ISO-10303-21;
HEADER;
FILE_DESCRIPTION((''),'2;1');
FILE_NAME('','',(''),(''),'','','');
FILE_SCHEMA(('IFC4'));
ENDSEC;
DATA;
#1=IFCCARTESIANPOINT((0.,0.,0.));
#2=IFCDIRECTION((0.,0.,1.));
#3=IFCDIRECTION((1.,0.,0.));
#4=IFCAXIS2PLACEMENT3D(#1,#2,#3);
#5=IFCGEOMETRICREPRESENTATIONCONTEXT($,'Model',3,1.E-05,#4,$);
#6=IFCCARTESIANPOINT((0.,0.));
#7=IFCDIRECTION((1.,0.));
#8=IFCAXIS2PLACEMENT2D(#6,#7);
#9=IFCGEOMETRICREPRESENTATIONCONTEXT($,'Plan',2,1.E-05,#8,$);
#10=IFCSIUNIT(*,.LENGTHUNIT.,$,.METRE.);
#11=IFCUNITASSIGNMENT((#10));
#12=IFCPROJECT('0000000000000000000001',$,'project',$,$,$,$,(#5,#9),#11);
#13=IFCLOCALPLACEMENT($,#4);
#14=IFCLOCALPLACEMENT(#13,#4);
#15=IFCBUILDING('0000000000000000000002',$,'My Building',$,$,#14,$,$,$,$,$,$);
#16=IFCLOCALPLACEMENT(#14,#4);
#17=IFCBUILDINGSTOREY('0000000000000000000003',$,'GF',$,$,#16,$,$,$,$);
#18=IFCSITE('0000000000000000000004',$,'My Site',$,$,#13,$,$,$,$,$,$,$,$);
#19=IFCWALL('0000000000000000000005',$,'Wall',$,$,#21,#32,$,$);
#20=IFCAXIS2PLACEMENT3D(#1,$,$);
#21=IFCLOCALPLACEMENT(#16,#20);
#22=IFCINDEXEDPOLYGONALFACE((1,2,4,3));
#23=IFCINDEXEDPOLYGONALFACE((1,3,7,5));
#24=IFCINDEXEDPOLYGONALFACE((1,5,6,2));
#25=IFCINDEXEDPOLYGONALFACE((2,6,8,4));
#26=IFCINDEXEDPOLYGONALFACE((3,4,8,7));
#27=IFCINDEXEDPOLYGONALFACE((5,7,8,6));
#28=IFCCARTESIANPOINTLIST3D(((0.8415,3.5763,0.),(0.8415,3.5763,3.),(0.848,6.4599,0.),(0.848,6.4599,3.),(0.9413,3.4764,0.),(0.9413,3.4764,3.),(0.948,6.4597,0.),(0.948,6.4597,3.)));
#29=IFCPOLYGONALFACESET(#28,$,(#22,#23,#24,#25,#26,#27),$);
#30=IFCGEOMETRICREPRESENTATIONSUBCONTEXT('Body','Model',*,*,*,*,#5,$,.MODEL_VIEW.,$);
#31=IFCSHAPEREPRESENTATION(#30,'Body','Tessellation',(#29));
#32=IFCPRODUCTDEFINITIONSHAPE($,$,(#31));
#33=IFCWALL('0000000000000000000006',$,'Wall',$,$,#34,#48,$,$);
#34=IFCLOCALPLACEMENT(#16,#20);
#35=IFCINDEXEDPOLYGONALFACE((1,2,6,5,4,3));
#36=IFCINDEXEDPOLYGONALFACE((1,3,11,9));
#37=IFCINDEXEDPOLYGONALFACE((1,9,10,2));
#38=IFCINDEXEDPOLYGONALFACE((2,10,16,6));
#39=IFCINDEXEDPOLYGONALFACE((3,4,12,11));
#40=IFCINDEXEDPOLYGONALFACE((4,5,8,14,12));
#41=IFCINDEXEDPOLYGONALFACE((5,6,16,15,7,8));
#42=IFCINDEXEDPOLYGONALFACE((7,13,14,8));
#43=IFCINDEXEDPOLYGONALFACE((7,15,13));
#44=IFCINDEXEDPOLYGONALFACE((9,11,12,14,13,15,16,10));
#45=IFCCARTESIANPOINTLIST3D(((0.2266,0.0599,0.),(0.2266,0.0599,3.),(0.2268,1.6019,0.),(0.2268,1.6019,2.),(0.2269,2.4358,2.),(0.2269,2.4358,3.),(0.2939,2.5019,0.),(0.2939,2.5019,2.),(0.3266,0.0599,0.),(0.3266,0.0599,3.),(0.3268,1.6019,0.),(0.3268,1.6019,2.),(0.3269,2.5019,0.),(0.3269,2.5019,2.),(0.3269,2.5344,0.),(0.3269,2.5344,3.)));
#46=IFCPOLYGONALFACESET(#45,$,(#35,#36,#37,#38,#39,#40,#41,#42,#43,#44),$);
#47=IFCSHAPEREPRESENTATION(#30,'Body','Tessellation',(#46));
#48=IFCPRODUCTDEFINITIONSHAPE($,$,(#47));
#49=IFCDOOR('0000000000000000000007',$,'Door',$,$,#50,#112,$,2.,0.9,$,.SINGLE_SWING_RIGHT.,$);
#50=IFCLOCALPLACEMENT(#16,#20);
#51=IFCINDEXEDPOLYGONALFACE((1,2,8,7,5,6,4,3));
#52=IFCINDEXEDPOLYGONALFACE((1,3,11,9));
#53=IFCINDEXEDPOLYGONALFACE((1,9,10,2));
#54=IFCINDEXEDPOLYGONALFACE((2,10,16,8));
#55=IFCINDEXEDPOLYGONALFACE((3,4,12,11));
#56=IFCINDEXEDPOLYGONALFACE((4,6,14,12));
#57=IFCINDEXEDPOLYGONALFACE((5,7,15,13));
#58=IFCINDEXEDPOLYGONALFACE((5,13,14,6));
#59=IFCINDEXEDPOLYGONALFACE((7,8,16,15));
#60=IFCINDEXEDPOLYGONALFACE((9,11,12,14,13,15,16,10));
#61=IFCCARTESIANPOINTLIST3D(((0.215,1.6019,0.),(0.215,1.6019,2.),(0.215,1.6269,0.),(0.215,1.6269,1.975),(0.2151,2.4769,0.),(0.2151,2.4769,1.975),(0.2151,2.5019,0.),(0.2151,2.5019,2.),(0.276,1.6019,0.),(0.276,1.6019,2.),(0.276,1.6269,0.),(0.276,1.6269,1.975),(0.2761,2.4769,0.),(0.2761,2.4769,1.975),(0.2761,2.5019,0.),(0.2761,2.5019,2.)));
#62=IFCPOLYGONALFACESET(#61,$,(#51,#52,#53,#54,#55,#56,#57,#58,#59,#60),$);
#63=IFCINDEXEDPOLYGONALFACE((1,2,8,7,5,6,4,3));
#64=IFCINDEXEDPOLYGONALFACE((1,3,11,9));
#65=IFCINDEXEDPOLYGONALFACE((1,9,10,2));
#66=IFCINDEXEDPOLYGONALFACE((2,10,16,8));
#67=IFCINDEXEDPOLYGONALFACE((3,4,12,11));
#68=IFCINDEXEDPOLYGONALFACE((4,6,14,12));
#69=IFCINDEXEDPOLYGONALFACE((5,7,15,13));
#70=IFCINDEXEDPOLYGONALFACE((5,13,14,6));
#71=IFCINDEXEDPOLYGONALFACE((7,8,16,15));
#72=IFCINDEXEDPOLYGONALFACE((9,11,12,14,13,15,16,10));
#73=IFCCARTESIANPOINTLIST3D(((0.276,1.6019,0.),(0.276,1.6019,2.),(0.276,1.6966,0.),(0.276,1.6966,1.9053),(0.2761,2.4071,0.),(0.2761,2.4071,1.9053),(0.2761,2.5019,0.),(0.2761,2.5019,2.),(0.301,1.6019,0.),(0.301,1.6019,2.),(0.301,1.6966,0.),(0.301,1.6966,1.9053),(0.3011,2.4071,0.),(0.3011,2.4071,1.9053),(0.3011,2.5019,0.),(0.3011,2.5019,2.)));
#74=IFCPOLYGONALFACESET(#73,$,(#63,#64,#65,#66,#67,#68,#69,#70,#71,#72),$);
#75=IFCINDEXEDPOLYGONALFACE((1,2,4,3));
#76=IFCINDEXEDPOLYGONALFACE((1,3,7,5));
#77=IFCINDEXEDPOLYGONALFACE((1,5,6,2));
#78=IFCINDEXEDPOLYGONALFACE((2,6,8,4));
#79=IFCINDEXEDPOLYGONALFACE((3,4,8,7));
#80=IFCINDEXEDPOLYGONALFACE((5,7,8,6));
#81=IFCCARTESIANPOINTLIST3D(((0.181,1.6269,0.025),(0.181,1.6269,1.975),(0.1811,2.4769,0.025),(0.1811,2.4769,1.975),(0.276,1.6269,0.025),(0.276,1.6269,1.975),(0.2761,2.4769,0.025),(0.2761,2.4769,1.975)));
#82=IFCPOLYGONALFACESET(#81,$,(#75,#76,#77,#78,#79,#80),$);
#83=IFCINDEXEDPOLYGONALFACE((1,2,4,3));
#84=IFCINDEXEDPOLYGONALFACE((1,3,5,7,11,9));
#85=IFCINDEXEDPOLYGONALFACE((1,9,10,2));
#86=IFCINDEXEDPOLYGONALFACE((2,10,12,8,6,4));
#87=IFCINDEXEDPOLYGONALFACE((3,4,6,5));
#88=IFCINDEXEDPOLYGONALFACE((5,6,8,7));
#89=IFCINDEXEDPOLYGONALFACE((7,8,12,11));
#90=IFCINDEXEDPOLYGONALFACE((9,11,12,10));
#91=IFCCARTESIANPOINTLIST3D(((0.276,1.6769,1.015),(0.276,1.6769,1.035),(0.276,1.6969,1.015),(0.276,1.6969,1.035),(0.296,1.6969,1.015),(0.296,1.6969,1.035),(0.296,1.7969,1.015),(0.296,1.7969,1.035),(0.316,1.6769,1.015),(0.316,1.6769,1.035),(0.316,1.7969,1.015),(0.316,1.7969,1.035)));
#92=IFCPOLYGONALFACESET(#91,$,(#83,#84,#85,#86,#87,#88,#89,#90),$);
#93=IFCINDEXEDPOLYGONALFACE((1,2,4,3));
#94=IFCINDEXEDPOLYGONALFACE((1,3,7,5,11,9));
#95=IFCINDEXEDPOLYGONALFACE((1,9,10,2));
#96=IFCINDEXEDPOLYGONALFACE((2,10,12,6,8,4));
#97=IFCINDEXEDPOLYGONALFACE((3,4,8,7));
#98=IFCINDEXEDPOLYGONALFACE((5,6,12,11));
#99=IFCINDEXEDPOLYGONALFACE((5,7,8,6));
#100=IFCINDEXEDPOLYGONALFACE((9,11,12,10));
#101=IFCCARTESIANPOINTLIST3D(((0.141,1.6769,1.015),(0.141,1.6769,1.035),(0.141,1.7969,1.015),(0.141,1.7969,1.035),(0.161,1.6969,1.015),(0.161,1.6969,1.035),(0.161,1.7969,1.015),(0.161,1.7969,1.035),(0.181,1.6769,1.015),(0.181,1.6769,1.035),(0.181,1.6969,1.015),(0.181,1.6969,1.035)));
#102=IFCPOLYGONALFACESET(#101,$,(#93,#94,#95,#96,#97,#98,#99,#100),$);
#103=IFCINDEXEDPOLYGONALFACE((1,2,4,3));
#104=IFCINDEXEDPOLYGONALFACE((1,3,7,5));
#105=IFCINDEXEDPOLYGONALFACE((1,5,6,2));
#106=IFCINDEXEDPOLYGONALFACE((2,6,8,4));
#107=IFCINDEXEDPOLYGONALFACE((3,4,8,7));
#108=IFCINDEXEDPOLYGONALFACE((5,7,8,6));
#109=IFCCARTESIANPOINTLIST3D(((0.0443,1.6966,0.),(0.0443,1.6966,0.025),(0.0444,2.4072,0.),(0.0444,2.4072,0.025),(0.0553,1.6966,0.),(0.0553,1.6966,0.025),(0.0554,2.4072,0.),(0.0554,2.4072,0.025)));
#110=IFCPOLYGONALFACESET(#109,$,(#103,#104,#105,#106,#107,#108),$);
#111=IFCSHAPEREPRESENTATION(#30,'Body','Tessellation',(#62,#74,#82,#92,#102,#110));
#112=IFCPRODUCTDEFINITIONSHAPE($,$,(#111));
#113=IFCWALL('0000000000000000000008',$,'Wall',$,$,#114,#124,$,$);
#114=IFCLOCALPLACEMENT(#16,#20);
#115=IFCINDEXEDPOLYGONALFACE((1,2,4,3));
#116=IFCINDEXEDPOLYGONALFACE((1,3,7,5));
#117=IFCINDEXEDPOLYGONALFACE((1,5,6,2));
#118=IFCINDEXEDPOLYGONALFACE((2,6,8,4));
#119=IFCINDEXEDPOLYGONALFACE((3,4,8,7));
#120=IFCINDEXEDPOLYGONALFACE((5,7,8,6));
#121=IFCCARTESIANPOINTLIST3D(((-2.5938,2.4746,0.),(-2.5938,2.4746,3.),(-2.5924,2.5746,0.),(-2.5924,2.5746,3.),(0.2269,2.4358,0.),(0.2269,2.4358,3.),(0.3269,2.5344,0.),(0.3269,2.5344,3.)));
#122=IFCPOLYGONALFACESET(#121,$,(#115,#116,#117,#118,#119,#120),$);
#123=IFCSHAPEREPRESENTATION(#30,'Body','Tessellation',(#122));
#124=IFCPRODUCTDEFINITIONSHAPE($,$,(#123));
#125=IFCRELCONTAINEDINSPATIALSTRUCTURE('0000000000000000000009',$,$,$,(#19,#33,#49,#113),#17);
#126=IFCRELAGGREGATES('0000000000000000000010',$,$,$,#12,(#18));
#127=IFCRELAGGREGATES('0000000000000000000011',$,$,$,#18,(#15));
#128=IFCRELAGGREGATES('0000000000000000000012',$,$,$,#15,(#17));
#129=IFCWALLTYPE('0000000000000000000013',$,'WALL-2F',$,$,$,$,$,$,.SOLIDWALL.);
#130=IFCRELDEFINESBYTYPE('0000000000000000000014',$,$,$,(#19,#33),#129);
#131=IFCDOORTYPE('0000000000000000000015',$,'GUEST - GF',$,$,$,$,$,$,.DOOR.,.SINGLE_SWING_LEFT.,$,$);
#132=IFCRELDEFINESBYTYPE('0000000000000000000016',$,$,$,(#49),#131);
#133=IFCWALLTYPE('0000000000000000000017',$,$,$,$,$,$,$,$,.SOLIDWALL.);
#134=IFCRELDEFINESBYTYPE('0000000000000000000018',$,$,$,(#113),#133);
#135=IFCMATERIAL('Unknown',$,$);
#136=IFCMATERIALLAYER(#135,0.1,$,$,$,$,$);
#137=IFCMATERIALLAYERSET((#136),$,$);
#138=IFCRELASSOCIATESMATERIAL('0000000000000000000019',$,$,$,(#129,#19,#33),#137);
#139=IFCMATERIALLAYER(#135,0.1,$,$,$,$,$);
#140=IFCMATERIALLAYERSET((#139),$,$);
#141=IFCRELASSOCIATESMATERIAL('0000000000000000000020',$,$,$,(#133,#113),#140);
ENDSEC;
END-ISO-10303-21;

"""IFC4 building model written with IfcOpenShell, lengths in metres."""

from ifc_helpers import new_model, entity, si_unit, frame, origin_with_axes, origin_2d_with_axis, place, context, subcontext, project, spatial, line, indexed_curve, outline, extrude, shape, source, transform, mapped, material, layer, layer_set, layer_usage, type_object, type_shapes, element, fill, save


model = new_model("IFC4")

# Units and contexts
model_context = context("Model", 3, precision=1e-05, world=origin_with_axes())
plan_context = context("Plan", 2, precision=1e-05, world=origin_2d_with_axis())
body_context_1 = subcontext(model_context, "Body", "Model", "MODEL_VIEW")
body_context_2 = subcontext(plan_context, "Body", "Plan", "PLAN_VIEW")
ifc_project = project(units=[si_unit("LENGTHUNIT", "METRE")], contexts=[model_context, plan_context])

# Site, building, storey
site_placement = place(None, origin_with_axes())
site = spatial("IfcSite", under=ifc_project, at=site_placement, Name="My Site")
building_placement = place(site_placement, origin_with_axes())
building = spatial("IfcBuilding", under=site, at=building_placement, Name="My Building")
storey_placement = place(building_placement, origin_with_axes())
storey = spatial("IfcBuildingStorey", under=building, at=storey_placement, Name="GF")

# Shared definitions
ifc_material_1 = material(Name="Unknown")

# Shared definitions
ifc_layer_1 = layer(ifc_material_1, 0.1)
ifc_layer_set_1 = layer_set([ifc_layer_1])
wall_type_1 = type_object("IfcWallType", Name="WALL-2F", PredefinedType="SOLIDWALL", material=ifc_layer_set_1)

# Wall
ifc_layer_usage_1 = layer_usage(ifc_layer_set_1, "AXIS2", "POSITIVE", 0.0)
wall_1_placement = place(storey_placement, frame((0.848, 6.4599, 0.0), z_axis=(0.0, 0.0, 1.0), x_axis=(-0.00226, -0.999997, 0.0)))
element("IfcWall", 1, at=wall_1_placement, inside=storey, type_object=wall_type_1, material=ifc_layer_usage_1, Name="Wall", context=body_context_1, shape_type="SweptSolid", body=[
    extrude(outline(indexed_curve([(0.0, 0.0), (0.0, 0.1), (2.9833, 0.1), (2.8836, 0.0)], segments=[line(1, 2, 3, 4, 1)])), origin_with_axes(), (0.0, 0.0, 1.0), 3.0),
])

# Wall, opening, door
ifc_layer_usage_2 = layer_usage(ifc_layer_set_1, "AXIS2", "POSITIVE", 0.0)
wall_2_placement = place(storey_placement, frame((0.2269, 2.5358, 0.0), z_axis=(0.0, 0.0, 1.0), x_axis=(-0.000105, -1.0, 0.0)))
wall_2 = element("IfcWall", 2, at=wall_2_placement, inside=storey, type_object=wall_type_1, material=ifc_layer_usage_2, Name="Wall", context=body_context_1, shape_type="SweptSolid", body=[
    extrude(outline(indexed_curve([(0.1, 0.0), (0.0014, 0.1), (2.4759, 0.1), (2.4759, 0.0)], segments=[line(1, 2, 3, 4, 1)])), origin_with_axes(), (0.0, 0.0, 1.0), 3.0),
])
shared_shape_1 = source(origin_with_axes(), body_context_1, "Body", "SweptSolid", [
    extrude(outline(indexed_curve([(0.0, 0.0), (0.9, 0.0), (0.9, 2.0), (0.0, 2.0)], segments=[line(1, 2, 3, 4, 1)])), frame((0.0, -0.6, 0.0), z_axis=(0.0, -1.0, 0.0), x_axis=(1.0, 0.0, 0.0)), (0.0, 0.0, -1.0), 1.2),
])
opening_1_placement = place(wall_2_placement, frame((0.9339, 0.2103, 0.0), z_axis=(0.0, 0.0, 1.0), x_axis=(-1.0, 0.0, 0.0)))
opening_1 = element("IfcOpeningElement", 3, at=opening_1_placement, cuts=wall_2, PredefinedType="OPENING", context=body_context_1, shape_type="MappedRepresentation", body=[
    mapped(shared_shape_1, transform((0.0, 0.0, 0.0), x_axis=(1.0, 0.0, 0.0), y_axis=(0.0, 1.0, 0.0), z_axis=(0.0, 0.0, 1.0), scale=1.0)),
])
door_type_1 = type_object("IfcDoorType", Name="GUEST - GF", OperationType="SINGLE_SWING_LEFT", PredefinedType="DOOR")
shared_shape_2 = source(origin_with_axes(), body_context_1, "Body", "SweptSolid", [
    extrude(outline(indexed_curve([(0.0, 0.0), (0.0, 2.0), (0.9, 2.0), (0.9, 0.0), (0.875, 0.0), (0.875, 1.975), (0.025, 1.975), (0.025, 0.0)], segments=[line(1, 2, 3, 4, 5, 6, 7, 8, 1)])), frame((0.0, 0.0093, 0.0), z_axis=(0.0, -1.0, 0.0), x_axis=(1.0, 0.0, 0.0)), (0.0, 0.0, -1.0), 0.061),
    extrude(outline(indexed_curve([(0.0, 0.0), (0.0, 2.0), (0.9, 2.0), (0.9, 0.0), (0.8053, 0.0), (0.8053, 1.9053), (0.0947, 1.9053), (0.0947, 0.0)], segments=[line(1, 2, 3, 4, 5, 6, 7, 8, 1)])), frame((0.0, -0.0157, 0.0), z_axis=(0.0, -1.0, 0.0), x_axis=(1.0, 0.0, 0.0)), (0.0, 0.0, -1.0), 0.025),
    extrude(outline(indexed_curve([(0.0, 0.0), (0.85, 0.0), (0.85, 0.095), (0.0, 0.095)], segments=[line(1, 2, 3, 4, 1)])), frame((0.025, 0.0093, 0.025), z_axis=(0.0, 0.0, 1.0), x_axis=(1.0, 0.0, 0.0)), (0.0, 0.0, 1.0), 1.95),
    extrude(outline(indexed_curve([(0.0, 0.0), (0.0, -0.04), (0.12, -0.04), (0.12, -0.02), (0.02, -0.02), (0.02, 0.0)], segments=[line(1, 2, 3, 4, 5, 6, 1)])), frame((0.075, 0.0093, 1.015), z_axis=(0.0, 0.0, 1.0), x_axis=(1.0, 0.0, 0.0)), (0.0, 0.0, 1.0), 0.02),
    extrude(outline(indexed_curve([(0.0, 0.0), (0.0, 0.04), (0.12, 0.04), (0.12, 0.02), (0.02, 0.02), (0.02, 0.0)], segments=[line(1, 2, 3, 4, 5, 6, 1)])), frame((0.075, 0.1043, 1.015), z_axis=(0.0, 0.0, 1.0), x_axis=(1.0, 0.0, 0.0)), (0.0, 0.0, 1.0), 0.02),
    extrude(outline(indexed_curve([(0.0, 0.0), (0.7105, 0.0), (0.7105, 0.011), (0.0, 0.011)], segments=[line(1, 2, 3, 4, 1)])), frame((0.0947, 0.23, 0.0), z_axis=(0.0, 0.0, 1.0), x_axis=(1.0, 0.0, 0.0)), (0.0, 0.0, 1.0), 0.025),
])
shared_shape_3 = source(origin_with_axes(), body_context_2, "Body", "Curve2D", [
    entity("IfcIndexedPolyCurve", entity("IfcCartesianPointList2D", [[0.0, -0.0157], [0.0, 0.0703], [0.025, 0.0703], [0.025, 0.0093], [0.0947, 0.0093], [0.0947, -0.0157]]), [entity("IfcLineIndex", [1, 2, 3, 4, 5, 6, 1])]),
    entity("IfcIndexedPolyCurve", entity("IfcCartesianPointList2D", [[0.9, -0.0157], [0.9, 0.0703], [0.875, 0.0703], [0.875, 0.0093], [0.8053, 0.0093], [0.8053, -0.0157]]), [entity("IfcLineIndex", [1, 2, 3, 4, 5, 6, 1])]),
    entity("IfcTrimmedCurve", entity("IfcEllipse", entity("IfcAxis2Placement2D", entity("IfcCartesianPoint", [0.78, 0.0703]), entity("IfcDirection", [1.0, 0.0])), 0.755, 0.85), [entity("IfcCartesianPoint", [0.78, 0.9203])], [entity("IfcCartesianPoint", [0.025, 0.0703])], True, "CARTESIAN"),
    entity("IfcIndexedPolyCurve", entity("IfcCartesianPointList2D", [[0.875, 0.0703], [0.78, 0.0703], [0.78, 0.9203], [0.875, 0.9203]]), [entity("IfcLineIndex", [1, 2, 3, 4, 1])]),
])
type_shapes(door_type_1, [shared_shape_2, shared_shape_3])
door_1_placement = place(opening_1_placement, frame((0.0, 0.1518, 0.0), z_axis=(0.0, 0.0, 1.0), x_axis=(1.0, 0.0, 0.0)))
door_1 = element("IfcDoor", 4, at=door_1_placement, inside=storey, type_object=door_type_1, Name="Door", OperationType="SINGLE_SWING_RIGHT", OverallHeight=2.0, OverallWidth=0.9, shapes=[
    shape(body_context_1, "Body", "MappedRepresentation", [mapped(shared_shape_2, transform((0.0, 0.0, 0.0), x_axis=(1.0, 0.0, 0.0), y_axis=(0.0, 1.0, 0.0), z_axis=(0.0, 0.0, 1.0), scale=1.0))]),
    shape(body_context_2, "Body", "MappedRepresentation", [mapped(shared_shape_3, transform((0.0, 0.0, 0.0), x_axis=(1.0, 0.0, 0.0), y_axis=(0.0, 1.0, 0.0), z_axis=(0.0, 0.0, 1.0), scale=1.0))]),
])
fill(opening_1, door_1)

# Wall
ifc_layer_2 = layer(ifc_material_1, 0.1)
ifc_layer_set_2 = layer_set([ifc_layer_2])
ifc_layer_usage_3 = layer_usage(ifc_layer_set_2, "AXIS2", "POSITIVE", 0.0)
wall_type_2 = type_object("IfcWallType", PredefinedType="SOLIDWALL", material=ifc_layer_set_2)
wall_3_placement = place(storey_placement, frame((0.2269, 2.5358, 0.0), z_axis=(0.0, 0.0, 1.0), x_axis=(-0.999905, 0.013761, 0.0)))
element("IfcWall", 5, at=wall_3_placement, inside=storey, type_object=wall_type_2, material=ifc_layer_usage_3, Name="Wall", context=body_context_1, shape_type="SweptSolid", body=[
    extrude(outline(indexed_curve([(-0.1, 0.0), (-0.0014, 0.1), (2.8195, 0.1), (2.8195, 0.0)], segments=[line(1, 2, 3, 4, 1)])), origin_with_axes(), (0.0, 0.0, 1.0), 3.0),
])

save(model, "model.ifc")
